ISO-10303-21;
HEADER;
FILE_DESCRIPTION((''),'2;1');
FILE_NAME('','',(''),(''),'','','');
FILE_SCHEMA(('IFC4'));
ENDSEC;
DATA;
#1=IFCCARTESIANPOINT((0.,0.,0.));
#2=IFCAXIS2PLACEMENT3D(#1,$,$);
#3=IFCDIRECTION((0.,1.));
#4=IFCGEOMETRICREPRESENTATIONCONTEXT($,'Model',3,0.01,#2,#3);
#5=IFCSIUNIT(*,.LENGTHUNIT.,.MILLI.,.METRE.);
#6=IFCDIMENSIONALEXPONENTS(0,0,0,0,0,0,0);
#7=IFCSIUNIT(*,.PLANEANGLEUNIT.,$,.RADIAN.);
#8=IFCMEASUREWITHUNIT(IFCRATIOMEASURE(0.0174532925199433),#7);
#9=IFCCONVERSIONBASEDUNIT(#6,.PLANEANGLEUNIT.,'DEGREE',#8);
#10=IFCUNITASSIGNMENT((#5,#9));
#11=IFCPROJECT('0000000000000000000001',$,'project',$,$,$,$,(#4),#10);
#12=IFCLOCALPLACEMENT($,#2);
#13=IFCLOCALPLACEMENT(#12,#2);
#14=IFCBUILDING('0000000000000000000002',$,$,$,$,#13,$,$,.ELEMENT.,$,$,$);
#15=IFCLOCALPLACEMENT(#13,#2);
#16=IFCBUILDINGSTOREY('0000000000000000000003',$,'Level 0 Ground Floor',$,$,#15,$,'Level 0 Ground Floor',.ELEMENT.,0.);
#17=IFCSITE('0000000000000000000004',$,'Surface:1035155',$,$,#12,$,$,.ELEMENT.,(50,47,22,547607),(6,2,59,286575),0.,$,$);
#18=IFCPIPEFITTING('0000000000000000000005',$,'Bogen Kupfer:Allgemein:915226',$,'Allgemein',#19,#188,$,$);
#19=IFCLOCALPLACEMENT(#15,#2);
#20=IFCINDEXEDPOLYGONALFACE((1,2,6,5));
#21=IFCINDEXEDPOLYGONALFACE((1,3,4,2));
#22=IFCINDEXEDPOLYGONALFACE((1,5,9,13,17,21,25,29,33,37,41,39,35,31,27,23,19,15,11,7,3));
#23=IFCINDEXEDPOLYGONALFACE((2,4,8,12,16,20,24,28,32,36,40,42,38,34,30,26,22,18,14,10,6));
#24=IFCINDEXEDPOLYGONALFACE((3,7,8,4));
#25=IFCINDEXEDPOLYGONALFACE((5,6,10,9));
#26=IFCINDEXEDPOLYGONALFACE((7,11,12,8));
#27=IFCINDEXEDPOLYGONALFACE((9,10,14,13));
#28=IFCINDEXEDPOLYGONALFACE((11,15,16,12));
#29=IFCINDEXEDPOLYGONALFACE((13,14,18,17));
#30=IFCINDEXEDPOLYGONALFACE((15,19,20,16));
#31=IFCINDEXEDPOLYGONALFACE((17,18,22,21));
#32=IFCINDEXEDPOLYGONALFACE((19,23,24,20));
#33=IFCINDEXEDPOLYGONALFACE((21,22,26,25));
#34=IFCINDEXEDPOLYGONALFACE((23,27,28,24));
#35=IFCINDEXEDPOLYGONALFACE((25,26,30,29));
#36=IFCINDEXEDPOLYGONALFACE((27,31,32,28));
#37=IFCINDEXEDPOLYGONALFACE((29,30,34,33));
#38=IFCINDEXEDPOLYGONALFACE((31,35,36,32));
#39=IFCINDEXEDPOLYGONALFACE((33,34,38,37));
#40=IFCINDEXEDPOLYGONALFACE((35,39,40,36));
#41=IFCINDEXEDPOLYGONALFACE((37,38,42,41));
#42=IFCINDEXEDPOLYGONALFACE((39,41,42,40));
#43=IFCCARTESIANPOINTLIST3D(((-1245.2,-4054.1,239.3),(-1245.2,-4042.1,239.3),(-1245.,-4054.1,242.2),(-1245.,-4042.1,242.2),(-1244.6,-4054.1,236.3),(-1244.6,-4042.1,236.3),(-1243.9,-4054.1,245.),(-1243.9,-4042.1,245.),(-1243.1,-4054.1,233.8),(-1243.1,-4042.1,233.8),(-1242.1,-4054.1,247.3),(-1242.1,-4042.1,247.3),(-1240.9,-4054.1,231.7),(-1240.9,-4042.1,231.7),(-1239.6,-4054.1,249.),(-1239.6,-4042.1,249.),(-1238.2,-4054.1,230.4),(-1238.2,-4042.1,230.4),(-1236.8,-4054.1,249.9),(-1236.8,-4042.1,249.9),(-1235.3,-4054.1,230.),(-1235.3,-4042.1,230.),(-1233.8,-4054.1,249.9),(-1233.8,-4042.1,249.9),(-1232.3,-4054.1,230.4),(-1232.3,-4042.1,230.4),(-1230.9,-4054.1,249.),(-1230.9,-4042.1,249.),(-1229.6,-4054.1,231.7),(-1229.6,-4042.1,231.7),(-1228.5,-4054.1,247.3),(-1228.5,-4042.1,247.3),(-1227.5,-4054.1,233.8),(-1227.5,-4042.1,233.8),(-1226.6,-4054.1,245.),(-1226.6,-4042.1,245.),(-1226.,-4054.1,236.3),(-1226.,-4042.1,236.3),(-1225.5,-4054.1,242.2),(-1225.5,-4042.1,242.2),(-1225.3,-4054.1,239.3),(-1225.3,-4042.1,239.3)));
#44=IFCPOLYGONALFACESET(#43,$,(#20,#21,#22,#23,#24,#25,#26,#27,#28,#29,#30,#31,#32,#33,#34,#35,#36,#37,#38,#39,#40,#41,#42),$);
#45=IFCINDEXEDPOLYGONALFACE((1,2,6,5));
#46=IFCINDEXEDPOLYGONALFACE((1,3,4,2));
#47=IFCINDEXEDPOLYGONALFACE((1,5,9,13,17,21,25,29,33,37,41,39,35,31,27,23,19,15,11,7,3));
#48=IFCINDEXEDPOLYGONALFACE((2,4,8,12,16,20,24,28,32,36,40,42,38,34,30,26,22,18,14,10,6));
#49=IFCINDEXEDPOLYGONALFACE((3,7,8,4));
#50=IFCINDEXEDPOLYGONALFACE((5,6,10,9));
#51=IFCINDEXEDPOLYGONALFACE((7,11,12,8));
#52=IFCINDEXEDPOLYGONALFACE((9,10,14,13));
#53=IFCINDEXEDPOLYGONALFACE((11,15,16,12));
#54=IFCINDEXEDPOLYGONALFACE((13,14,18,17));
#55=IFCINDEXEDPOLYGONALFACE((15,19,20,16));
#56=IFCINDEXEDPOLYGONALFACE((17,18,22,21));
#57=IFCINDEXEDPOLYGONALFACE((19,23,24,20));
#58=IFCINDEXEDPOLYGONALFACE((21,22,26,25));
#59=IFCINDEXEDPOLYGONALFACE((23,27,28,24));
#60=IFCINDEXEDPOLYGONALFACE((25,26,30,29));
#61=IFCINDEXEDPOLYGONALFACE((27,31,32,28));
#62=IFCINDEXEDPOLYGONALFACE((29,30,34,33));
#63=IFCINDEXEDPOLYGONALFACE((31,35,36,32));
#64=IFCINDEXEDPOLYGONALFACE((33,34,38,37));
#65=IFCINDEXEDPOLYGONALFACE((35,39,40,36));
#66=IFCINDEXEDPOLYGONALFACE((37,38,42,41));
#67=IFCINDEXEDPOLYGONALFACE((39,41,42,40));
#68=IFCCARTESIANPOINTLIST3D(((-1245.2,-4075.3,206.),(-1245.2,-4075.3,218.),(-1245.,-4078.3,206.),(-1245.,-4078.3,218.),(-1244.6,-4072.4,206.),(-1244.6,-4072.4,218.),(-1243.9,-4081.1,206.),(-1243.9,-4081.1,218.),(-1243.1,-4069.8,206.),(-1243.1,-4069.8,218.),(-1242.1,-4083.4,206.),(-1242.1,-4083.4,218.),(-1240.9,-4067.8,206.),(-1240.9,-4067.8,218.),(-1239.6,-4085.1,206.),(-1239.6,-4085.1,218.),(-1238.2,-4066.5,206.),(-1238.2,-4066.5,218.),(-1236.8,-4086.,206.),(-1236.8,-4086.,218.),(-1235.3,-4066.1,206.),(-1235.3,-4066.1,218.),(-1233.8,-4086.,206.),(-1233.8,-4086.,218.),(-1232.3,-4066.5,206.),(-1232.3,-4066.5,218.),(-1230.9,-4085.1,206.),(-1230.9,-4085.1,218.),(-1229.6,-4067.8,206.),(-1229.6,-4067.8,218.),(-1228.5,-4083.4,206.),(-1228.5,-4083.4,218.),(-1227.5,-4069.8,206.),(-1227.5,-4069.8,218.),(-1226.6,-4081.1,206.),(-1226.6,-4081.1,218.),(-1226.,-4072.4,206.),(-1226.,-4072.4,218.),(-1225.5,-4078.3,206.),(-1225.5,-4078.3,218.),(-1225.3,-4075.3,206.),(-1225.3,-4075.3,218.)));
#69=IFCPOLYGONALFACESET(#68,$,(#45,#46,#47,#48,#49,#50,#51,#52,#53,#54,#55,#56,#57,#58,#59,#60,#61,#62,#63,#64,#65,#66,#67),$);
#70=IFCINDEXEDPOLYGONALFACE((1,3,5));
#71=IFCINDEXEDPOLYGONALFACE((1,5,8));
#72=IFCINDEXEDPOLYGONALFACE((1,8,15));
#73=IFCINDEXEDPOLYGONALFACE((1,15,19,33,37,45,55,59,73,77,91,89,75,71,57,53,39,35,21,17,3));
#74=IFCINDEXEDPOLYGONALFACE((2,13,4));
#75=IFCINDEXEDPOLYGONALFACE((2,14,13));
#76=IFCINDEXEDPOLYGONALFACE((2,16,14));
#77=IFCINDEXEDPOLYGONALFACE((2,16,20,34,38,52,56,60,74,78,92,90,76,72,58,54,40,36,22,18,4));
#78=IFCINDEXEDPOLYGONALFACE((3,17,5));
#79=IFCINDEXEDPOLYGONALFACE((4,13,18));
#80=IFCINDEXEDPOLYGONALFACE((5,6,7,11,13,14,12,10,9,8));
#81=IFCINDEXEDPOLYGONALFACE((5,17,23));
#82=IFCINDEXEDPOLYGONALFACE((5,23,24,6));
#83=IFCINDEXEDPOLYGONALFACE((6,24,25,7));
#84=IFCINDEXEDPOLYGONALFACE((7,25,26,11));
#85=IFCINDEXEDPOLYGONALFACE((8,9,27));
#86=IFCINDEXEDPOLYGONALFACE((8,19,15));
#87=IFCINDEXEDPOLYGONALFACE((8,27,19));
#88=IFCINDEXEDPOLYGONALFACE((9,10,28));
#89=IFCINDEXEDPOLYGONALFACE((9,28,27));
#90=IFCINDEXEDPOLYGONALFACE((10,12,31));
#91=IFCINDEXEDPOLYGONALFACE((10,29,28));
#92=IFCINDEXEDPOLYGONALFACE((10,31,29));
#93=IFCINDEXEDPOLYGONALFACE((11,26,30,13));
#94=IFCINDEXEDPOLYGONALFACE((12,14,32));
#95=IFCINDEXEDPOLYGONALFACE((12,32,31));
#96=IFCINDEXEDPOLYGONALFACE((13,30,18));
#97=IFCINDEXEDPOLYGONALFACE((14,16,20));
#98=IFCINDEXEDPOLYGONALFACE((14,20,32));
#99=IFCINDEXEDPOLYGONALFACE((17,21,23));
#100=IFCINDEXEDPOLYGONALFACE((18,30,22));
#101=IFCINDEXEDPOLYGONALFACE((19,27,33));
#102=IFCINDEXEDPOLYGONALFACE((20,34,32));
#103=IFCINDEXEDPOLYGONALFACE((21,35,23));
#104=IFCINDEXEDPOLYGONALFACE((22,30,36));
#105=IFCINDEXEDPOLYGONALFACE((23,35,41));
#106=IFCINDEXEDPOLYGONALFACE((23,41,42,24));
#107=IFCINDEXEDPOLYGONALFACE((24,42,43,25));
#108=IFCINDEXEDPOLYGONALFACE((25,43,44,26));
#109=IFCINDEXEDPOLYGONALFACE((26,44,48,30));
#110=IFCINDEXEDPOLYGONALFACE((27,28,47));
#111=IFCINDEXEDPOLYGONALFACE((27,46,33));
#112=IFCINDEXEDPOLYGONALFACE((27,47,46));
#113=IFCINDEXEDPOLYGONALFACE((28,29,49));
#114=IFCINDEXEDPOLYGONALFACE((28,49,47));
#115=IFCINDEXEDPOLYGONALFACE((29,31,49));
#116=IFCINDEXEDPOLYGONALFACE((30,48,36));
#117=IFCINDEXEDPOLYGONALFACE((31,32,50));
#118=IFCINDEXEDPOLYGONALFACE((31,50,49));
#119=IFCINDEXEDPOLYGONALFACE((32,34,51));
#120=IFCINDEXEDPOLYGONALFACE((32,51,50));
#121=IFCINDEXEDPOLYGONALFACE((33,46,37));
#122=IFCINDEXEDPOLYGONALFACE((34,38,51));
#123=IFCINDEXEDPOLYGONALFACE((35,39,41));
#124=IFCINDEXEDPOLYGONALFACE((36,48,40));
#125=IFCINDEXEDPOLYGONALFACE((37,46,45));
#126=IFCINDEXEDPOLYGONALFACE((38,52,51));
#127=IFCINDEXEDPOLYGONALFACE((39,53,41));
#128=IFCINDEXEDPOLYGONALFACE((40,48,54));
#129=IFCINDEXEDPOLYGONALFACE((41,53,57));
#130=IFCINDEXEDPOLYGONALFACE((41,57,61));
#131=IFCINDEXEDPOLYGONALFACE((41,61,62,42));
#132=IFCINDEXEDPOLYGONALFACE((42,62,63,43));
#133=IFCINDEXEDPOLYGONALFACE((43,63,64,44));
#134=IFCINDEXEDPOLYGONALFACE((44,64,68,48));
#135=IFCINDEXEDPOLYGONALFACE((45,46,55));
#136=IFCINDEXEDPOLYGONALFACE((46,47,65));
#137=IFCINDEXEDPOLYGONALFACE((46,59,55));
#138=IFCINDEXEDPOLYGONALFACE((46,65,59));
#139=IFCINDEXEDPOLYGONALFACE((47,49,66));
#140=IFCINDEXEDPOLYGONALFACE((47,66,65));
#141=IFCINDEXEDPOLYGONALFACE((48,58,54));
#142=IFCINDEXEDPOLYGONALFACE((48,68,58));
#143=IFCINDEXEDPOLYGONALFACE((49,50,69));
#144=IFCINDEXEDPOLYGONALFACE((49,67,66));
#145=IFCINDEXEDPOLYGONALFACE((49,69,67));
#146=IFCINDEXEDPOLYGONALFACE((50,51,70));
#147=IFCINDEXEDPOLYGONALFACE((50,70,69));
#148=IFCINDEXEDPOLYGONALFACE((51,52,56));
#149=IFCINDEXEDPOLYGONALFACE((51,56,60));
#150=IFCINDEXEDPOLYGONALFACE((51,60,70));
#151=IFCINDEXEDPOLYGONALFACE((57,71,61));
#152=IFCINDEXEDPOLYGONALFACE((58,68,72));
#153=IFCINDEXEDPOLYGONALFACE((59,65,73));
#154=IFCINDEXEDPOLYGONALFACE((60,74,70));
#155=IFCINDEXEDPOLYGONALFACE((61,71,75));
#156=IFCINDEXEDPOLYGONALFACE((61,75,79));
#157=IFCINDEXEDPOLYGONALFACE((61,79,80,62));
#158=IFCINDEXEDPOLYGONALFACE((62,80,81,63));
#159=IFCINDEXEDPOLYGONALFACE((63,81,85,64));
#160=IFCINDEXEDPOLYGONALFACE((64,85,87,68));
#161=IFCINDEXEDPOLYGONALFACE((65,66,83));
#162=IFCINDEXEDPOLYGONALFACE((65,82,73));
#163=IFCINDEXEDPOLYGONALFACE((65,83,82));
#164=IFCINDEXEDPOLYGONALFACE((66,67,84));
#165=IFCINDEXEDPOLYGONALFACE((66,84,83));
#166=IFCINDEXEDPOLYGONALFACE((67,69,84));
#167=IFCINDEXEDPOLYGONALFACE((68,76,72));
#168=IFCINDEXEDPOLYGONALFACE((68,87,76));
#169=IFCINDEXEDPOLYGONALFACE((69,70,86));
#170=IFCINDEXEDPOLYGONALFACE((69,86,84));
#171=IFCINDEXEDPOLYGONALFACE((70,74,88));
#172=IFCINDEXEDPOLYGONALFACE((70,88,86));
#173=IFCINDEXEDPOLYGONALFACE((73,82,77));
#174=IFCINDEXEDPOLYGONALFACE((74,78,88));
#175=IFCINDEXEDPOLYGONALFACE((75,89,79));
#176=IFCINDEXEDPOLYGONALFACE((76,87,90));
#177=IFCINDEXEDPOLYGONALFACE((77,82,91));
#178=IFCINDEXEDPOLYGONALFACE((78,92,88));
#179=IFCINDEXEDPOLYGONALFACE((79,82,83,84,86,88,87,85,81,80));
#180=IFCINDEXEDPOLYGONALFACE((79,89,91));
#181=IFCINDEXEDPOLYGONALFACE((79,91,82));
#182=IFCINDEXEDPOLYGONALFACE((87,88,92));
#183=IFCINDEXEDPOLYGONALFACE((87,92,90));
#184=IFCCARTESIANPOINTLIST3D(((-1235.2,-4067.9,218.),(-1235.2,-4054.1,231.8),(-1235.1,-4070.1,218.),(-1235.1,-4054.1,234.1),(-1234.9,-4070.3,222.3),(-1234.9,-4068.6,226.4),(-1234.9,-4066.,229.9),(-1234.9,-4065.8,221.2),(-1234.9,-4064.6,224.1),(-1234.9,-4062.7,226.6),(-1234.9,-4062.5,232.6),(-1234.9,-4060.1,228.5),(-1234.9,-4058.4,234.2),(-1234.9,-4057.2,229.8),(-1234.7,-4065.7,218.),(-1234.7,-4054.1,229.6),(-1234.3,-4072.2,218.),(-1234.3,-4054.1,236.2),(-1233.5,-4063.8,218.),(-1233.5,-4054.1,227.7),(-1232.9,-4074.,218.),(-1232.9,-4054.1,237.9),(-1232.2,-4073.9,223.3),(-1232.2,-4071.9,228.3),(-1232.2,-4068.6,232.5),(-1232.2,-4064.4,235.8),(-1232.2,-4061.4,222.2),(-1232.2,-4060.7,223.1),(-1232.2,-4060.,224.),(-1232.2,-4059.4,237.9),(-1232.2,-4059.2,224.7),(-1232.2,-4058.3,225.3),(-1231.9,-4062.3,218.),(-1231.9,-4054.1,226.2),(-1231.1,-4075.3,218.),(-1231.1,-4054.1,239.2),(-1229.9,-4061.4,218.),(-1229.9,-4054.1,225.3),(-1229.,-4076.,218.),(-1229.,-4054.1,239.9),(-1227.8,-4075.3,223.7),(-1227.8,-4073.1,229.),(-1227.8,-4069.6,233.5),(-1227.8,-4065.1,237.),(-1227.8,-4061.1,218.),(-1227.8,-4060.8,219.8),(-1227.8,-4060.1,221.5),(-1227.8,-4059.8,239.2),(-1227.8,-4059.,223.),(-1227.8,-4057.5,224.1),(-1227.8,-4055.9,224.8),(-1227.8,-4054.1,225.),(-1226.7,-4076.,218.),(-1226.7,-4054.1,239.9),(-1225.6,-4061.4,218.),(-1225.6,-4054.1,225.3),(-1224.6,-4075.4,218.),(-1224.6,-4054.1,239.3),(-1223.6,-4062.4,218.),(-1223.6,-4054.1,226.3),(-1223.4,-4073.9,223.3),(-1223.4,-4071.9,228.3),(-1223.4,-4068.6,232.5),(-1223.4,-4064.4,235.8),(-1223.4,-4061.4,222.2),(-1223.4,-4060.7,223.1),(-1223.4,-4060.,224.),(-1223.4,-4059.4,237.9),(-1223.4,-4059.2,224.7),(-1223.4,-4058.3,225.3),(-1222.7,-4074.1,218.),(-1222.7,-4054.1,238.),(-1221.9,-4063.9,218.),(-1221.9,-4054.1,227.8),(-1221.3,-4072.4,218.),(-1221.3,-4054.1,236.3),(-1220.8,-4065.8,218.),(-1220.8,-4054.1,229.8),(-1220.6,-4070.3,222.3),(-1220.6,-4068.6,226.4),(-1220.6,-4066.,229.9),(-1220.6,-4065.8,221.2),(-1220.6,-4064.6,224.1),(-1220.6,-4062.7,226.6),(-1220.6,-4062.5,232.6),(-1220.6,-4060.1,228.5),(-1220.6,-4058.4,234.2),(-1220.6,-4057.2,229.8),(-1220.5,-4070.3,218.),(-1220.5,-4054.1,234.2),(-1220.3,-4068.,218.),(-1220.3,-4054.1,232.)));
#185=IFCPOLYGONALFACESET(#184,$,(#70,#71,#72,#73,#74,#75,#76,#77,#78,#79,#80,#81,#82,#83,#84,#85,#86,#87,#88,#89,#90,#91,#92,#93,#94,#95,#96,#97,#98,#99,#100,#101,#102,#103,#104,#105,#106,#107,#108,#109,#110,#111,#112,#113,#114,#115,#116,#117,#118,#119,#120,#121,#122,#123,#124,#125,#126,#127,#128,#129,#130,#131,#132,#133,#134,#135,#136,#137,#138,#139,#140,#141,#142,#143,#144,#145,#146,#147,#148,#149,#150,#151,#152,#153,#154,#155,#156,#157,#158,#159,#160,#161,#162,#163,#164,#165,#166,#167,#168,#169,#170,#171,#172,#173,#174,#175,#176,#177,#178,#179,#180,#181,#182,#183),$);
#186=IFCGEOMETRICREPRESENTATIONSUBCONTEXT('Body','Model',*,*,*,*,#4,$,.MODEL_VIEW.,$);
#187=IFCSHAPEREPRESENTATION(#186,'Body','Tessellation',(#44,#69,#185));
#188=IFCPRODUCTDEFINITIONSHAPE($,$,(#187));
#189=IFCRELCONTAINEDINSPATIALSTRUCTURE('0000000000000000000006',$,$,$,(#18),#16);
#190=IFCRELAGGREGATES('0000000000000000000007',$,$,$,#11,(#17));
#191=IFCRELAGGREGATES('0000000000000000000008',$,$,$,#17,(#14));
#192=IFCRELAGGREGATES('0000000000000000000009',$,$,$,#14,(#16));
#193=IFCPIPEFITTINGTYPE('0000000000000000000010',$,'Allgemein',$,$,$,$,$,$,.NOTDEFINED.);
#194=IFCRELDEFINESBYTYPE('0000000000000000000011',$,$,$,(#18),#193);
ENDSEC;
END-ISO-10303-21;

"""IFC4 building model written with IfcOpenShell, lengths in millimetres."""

from ifc_helpers import new_model, entity, si_unit, converted_unit, direction, frame, frame_2d, origin, place, context, subcontext, project, spatial, circle, extrude, source, transform, mapped, type_object, type_shapes, element, save


model = new_model("IFC4")

# Units and contexts
model_context = context("Model", 3, precision=0.01, world=origin(), true_north=direction((0.0, 1.0)))
body_context = subcontext(model_context, "Body", "Model", "MODEL_VIEW")
ifc_project = project(units=[si_unit("LENGTHUNIT", "METRE", prefix="MILLI"), converted_unit("PLANEANGLEUNIT", "DEGREE", entity("IfcRatioMeasure", 0.0174532925199433), si_unit("PLANEANGLEUNIT", "RADIAN"), dimensions=[0, 0, 0, 0, 0, 0, 0])], contexts=[model_context])

# Site, building, storey
site_placement = place(None, origin())
site = spatial("IfcSite", under=ifc_project, at=site_placement, Name="Surface:1035155", CompositionType="ELEMENT", RefLatitude=(50, 47, 22, 547607), RefLongitude=(6, 2, 59, 286575), RefElevation=0.0)
building_placement = place(site_placement, origin())
building = spatial("IfcBuilding", under=site, at=building_placement, CompositionType="ELEMENT")
storey_placement = place(building_placement, origin())
storey = spatial("IfcBuildingStorey", under=building, at=storey_placement, Name="Level 0 Ground Floor", LongName="Level 0 Ground Floor", CompositionType="ELEMENT", Elevation=0.0)

# Pipe fitting
pipe_fitting_type = type_object("IfcPipeFittingType", Name="Allgemein", PredefinedType="NOTDEFINED")
ifc_direction = entity("IfcDirection", [0.0, 0.0, -1.0])
trimmed_curve = entity("IfcTrimmedCurve", entity("IfcCircle", entity("IfcAxis2Placement2D", entity("IfcCartesianPoint", [-14.5, 0.0]), entity("IfcDirection", [0.0, 1.0])), 14.5), [entity("IfcParameterValue", 270.0)], [entity("IfcParameterValue", 0.0)], True, "PARAMETER")
shared_shape_1 = source(origin(), body_context, "Body", "SolidModel", [
    extrude(circle(Radius=10.0, at=frame_2d((0.0, 0.0), x_axis=(1.0, 0.0))), frame((0.0, 22.0, 0.0), z_axis=(0.0, 1.0, 0.0), x_axis=(-1.0, 0.0, 0.0)), (0.0, 0.0, 1.0), 12.0),
    extrude(circle(Radius=10.0, at=frame_2d((0.0, 0.0), x_axis=(1.0, 0.0))), frame((-34.0, 0.0, 0.0), z_axis=(1.0, 0.0, 0.0), x_axis=(0.0, 1.0, 0.0)), (0.0, 0.0, 1.0), 12.0),
    entity("IfcSurfaceCurveSweptAreaSolid", entity("IfcCircleProfileDef", "AREA", None, entity("IfcAxis2Placement2D", entity("IfcCartesianPoint", [0.0, 7.5]), entity("IfcDirection", [1.0, 0.0])), 7.5), entity("IfcAxis2Placement3D", entity("IfcCartesianPoint", [-7.5, 22.0, 0.0]), ifc_direction, entity("IfcDirection", [1.0, 0.0, 0.0])), trimmed_curve, 0.0, 90.0, entity("IfcSurfaceOfLinearExtrusion", entity("IfcArbitraryOpenProfileDef", "CURVE", None, trimmed_curve), entity("IfcAxis2Placement3D", entity("IfcCartesianPoint", [0.0, 0.0, -304.8])), ifc_direction, 1.0)),
])
type_shapes(pipe_fitting_type, [shared_shape_1])
for number, where, z_axis, x_axis, name in (
    (1, (-1235.3, -4076.1, 240.0), (-1.0, 0.0, 0.0), (0.0, 0.0, 1.0), "Bogen Kupfer:Allgemein:915226"),
):
    element("IfcPipeFitting", number, at=place(storey_placement, frame(where, z_axis=z_axis, x_axis=x_axis)), inside=storey, type_object=pipe_fitting_type, Name=name, ObjectType="Allgemein", context=body_context, shape_type="MappedRepresentation", body=[
        mapped(shared_shape_1, transform((0.0, 0.0, 0.0), scale=1.0)),
    ])

save(model, "model.ifc")
